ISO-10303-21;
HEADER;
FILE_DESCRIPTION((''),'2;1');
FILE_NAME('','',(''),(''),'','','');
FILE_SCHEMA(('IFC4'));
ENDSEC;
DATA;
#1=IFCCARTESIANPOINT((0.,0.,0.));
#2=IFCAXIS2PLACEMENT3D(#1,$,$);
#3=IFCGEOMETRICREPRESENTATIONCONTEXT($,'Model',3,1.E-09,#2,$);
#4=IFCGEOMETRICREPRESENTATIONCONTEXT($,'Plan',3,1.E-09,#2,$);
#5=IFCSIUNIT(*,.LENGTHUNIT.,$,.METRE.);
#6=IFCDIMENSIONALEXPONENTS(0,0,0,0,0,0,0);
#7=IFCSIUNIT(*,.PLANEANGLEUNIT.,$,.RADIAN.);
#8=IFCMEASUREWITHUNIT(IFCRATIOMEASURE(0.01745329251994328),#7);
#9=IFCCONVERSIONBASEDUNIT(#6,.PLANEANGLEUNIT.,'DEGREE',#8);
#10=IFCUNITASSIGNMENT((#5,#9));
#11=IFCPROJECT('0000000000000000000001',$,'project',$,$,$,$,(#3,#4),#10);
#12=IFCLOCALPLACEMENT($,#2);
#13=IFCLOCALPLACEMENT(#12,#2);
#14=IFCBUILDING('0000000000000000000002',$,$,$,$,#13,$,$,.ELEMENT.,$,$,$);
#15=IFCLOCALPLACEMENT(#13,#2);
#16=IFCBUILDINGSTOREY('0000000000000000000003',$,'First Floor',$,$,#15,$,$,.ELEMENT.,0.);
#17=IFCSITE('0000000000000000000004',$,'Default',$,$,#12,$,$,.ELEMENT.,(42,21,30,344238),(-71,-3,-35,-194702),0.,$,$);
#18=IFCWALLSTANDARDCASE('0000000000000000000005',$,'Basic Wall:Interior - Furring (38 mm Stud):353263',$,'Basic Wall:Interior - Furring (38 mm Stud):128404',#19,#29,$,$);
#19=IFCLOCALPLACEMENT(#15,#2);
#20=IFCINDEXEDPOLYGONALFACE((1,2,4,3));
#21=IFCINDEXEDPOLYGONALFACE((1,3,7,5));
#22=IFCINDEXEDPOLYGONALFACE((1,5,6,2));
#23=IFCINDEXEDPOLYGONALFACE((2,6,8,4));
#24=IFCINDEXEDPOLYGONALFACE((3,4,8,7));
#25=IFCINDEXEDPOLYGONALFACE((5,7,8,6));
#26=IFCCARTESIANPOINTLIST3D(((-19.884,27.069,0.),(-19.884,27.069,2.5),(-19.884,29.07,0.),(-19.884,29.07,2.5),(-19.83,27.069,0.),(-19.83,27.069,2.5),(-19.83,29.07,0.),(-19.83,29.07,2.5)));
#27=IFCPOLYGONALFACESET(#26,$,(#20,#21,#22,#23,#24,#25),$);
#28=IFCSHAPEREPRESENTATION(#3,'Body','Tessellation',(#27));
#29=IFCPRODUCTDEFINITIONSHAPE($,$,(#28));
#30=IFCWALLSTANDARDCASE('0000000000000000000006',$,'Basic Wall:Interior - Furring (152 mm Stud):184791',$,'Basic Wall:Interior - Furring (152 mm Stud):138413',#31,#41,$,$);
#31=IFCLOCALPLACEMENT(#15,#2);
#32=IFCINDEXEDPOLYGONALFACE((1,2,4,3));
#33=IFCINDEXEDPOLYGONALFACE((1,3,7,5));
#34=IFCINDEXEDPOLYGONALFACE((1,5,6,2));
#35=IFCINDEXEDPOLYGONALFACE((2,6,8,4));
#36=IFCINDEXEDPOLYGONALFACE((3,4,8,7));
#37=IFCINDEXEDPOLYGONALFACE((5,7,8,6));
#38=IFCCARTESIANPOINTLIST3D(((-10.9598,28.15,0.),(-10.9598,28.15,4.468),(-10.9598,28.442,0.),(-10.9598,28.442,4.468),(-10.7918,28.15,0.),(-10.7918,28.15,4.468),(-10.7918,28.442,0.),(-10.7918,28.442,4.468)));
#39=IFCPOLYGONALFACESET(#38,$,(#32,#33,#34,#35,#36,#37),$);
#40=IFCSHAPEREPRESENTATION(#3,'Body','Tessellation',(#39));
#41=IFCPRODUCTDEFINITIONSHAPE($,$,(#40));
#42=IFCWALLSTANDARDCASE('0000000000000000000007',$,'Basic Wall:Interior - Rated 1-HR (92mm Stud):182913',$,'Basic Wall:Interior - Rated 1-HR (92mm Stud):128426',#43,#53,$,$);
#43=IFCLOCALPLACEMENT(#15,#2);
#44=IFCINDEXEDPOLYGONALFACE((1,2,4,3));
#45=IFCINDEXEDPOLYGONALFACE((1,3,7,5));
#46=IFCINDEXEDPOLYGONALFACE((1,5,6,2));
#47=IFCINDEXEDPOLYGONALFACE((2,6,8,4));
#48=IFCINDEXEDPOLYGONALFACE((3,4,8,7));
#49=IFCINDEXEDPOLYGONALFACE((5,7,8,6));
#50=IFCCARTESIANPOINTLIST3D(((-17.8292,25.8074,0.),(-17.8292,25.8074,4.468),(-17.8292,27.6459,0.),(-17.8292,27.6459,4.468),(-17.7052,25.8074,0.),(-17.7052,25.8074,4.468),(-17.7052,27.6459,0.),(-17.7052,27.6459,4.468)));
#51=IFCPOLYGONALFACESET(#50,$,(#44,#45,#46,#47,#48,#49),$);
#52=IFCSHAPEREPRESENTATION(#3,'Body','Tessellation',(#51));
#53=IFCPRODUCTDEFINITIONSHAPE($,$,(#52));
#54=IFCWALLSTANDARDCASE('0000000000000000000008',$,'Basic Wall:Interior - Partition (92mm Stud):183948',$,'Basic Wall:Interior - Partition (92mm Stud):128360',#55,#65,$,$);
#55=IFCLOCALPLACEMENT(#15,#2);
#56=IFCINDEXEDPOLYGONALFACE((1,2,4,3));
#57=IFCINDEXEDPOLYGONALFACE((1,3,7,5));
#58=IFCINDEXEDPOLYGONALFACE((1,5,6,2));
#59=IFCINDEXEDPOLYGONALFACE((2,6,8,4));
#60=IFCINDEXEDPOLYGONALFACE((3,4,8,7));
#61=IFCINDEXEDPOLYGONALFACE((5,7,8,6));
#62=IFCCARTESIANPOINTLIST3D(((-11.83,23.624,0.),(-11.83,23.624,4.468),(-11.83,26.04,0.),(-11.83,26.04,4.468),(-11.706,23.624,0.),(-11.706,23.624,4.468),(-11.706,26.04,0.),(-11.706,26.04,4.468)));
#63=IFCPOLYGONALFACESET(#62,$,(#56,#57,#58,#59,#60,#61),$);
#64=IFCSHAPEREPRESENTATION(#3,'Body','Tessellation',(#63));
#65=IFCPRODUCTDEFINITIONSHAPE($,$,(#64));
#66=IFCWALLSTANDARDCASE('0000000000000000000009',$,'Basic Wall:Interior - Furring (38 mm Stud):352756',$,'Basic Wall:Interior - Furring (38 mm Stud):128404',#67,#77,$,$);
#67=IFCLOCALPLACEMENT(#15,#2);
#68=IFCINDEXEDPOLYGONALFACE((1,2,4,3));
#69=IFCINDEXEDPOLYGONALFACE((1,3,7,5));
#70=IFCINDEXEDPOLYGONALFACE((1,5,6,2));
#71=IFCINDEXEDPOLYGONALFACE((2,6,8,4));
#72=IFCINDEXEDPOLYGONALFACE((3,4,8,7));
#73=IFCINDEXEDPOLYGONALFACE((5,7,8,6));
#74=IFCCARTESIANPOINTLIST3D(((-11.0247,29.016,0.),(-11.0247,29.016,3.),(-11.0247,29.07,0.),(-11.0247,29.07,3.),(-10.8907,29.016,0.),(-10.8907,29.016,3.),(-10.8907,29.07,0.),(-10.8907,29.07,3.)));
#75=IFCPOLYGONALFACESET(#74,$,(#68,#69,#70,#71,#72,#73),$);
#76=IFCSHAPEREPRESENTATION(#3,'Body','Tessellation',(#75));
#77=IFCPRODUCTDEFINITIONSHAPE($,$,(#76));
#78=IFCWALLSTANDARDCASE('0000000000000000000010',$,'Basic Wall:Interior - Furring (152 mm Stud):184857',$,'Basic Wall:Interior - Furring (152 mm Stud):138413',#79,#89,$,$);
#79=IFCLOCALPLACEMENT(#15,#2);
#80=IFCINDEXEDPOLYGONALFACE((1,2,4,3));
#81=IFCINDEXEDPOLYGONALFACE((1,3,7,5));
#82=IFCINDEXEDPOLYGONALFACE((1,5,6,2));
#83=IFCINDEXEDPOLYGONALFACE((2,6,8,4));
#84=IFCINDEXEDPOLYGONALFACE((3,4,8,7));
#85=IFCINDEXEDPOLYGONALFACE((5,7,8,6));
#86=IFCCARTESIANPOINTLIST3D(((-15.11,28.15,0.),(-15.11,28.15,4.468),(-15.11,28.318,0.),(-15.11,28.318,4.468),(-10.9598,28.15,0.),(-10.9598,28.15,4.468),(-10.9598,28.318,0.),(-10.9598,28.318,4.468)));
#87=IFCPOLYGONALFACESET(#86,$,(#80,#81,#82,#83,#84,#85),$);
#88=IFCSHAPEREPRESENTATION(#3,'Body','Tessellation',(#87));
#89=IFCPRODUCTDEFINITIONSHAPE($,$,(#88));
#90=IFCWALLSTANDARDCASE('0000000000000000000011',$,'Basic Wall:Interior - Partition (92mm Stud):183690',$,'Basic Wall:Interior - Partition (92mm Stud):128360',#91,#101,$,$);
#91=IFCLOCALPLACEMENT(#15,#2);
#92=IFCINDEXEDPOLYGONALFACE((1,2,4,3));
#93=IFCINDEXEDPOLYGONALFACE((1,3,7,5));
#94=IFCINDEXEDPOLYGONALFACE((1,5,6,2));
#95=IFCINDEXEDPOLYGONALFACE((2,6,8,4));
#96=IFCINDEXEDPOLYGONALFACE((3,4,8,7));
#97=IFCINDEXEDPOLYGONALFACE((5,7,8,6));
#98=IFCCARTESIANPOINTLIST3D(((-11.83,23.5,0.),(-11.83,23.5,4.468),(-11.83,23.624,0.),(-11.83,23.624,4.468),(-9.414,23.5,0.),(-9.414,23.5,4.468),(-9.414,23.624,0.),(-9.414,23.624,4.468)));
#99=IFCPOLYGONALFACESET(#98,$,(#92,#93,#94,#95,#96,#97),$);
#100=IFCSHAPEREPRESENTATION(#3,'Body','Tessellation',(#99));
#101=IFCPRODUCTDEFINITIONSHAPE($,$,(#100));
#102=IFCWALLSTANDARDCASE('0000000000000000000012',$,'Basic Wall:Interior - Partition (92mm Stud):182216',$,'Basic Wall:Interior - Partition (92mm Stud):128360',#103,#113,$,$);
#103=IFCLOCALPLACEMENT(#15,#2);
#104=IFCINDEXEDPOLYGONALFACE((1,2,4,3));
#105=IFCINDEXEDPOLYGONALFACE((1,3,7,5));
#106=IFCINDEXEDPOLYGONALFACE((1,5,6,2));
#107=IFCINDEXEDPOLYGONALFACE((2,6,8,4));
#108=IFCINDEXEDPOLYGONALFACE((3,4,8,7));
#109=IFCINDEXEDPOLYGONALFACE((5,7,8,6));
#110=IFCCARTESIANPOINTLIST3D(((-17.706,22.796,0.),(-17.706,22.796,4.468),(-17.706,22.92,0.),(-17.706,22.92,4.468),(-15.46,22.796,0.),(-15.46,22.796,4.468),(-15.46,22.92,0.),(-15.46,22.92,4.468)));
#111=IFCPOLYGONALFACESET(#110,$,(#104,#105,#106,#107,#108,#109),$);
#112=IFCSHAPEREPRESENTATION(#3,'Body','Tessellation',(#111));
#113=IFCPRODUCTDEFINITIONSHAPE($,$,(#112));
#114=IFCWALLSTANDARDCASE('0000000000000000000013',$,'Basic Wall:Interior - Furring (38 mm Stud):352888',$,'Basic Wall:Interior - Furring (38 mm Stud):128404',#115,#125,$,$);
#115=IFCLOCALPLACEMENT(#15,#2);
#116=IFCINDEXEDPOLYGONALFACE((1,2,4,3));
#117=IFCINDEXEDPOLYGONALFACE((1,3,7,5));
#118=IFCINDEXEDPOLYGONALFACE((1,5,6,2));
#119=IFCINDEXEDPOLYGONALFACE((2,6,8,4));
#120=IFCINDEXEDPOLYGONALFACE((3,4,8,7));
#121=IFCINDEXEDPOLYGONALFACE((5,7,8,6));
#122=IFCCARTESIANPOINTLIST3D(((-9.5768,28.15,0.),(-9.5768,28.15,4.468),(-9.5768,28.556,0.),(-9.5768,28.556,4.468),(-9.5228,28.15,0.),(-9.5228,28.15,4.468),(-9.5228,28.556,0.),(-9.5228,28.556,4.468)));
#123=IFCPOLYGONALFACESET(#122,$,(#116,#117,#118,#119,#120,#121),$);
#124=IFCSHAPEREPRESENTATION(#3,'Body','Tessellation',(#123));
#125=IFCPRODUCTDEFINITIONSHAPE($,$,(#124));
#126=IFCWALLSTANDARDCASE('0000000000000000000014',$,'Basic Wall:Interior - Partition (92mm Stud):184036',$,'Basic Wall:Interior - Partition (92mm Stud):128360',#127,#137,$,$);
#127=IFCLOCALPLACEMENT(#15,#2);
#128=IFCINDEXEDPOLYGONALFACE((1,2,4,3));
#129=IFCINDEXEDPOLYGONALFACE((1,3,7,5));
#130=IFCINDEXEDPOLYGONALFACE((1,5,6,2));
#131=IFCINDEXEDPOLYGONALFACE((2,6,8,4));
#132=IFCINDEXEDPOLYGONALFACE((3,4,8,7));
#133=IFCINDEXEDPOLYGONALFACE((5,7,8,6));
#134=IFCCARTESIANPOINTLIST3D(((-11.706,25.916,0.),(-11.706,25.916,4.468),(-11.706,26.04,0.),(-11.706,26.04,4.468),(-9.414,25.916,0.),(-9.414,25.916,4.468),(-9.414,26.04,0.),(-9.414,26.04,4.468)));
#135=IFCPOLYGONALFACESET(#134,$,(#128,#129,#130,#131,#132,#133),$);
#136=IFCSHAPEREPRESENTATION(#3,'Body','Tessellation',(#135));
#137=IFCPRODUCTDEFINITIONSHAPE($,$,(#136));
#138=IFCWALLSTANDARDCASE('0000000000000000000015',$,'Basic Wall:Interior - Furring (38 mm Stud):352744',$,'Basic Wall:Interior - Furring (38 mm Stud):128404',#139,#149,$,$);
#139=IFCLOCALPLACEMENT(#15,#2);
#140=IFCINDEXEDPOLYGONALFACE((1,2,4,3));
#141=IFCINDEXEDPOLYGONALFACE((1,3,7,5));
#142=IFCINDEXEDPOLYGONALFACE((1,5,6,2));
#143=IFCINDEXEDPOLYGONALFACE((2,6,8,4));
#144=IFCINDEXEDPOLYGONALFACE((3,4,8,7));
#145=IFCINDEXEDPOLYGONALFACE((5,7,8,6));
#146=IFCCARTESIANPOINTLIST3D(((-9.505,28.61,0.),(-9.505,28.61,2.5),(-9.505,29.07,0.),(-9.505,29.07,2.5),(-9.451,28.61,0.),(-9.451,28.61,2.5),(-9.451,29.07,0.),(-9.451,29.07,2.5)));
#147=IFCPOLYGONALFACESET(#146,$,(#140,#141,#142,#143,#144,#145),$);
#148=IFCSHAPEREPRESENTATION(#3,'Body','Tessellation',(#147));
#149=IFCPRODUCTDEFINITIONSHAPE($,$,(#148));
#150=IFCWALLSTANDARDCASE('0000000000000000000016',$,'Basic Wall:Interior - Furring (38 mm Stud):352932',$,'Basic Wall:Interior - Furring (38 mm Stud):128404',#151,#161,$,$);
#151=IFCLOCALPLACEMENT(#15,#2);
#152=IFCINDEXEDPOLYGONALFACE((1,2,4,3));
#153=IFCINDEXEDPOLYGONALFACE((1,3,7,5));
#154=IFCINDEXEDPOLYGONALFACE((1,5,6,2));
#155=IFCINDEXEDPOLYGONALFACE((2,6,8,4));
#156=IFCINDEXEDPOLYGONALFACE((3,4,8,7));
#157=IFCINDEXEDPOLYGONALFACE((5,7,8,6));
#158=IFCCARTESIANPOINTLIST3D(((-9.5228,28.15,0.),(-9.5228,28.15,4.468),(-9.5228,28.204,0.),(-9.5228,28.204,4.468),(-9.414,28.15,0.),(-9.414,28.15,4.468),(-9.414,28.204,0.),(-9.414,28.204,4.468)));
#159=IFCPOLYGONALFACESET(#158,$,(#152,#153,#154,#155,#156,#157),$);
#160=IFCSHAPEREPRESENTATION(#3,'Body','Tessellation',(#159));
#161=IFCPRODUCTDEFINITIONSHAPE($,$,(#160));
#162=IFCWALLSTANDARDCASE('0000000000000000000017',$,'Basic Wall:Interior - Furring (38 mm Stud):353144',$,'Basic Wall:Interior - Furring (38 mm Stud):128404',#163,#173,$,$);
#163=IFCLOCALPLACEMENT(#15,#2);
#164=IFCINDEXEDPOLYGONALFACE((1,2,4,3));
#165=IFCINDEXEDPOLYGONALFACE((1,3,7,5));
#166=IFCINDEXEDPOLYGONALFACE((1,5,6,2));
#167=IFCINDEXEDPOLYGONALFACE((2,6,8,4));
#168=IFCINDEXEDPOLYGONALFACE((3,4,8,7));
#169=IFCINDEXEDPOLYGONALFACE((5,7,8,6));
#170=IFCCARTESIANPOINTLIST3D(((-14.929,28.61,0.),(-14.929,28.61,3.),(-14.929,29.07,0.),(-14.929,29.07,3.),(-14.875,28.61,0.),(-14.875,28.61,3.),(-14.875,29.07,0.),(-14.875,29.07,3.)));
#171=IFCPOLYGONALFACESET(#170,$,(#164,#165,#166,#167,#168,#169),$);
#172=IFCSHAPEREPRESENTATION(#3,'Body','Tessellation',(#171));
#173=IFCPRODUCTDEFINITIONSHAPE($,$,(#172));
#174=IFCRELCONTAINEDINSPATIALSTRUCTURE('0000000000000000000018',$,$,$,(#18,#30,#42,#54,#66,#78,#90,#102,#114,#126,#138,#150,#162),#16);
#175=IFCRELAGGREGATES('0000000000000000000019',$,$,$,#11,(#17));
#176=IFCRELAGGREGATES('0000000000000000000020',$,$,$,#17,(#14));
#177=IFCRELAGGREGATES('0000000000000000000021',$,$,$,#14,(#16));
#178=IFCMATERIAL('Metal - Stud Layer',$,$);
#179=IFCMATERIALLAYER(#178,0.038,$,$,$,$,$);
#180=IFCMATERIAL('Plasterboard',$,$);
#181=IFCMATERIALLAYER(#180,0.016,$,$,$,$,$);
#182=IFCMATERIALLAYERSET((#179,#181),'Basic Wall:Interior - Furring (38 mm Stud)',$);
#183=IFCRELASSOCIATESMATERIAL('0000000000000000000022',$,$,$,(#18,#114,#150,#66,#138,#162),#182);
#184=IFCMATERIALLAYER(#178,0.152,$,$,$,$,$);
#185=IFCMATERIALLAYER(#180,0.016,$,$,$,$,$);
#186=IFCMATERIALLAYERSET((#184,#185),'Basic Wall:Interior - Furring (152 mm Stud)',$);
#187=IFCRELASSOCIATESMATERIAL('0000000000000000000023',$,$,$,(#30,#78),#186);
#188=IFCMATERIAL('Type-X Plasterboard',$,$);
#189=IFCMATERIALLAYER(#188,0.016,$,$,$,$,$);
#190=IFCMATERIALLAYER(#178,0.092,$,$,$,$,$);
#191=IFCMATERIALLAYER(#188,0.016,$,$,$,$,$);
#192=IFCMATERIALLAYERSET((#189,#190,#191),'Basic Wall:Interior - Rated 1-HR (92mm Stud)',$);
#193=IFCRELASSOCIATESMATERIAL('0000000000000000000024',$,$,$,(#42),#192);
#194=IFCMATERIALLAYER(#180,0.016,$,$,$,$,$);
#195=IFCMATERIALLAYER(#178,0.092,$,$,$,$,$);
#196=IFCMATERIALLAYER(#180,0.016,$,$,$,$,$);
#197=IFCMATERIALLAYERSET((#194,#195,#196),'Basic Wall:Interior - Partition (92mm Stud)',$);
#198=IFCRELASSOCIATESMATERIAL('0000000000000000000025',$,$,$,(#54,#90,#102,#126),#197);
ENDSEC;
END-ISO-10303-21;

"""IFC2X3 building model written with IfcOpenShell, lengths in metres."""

from ifc_helpers import new_model, entity, si_unit, converted_unit, frame, frame_2d, origin, place, context, project, spatial, rectangle, extrude, material, layer, layer_set, layer_usage, element, save


model = new_model("IFC2X3")

# Units and contexts
model_context = context("Model", 3, precision=1e-09, world=origin())
plan_context = context("Plan", 3, precision=1e-09, world=origin())
ifc_project = project(units=[si_unit("LENGTHUNIT", "METRE"), converted_unit("PLANEANGLEUNIT", "DEGREE", entity("IfcRatioMeasure", 0.01745329251994328), si_unit("PLANEANGLEUNIT", "RADIAN"), dimensions=[0, 0, 0, 0, 0, 0, 0])], contexts=[model_context, plan_context])

# Site, building, storey
site_placement = place(None, origin())
site = spatial("IfcSite", under=ifc_project, at=site_placement, Name="Default", CompositionType="ELEMENT", RefLatitude=(42, 21, 30, 344238), RefLongitude=(-71, -3, -35, -194702), RefElevation=0.0)
building_placement = place(site_placement, origin())
building = spatial("IfcBuilding", under=site, at=building_placement, CompositionType="ELEMENT")
storey_placement = place(building_placement, origin())
storey = spatial("IfcBuildingStorey", under=building, at=storey_placement, Name="First Floor", CompositionType="ELEMENT", Elevation=0.0)

# Shared definitions
ifc_material_1 = material(Name="Type-X Plasterboard")
ifc_layer_1 = layer(ifc_material_1, 0.016)
ifc_material_2 = material(Name="Metal - Stud Layer")
ifc_layer_2 = layer(ifc_material_2, 0.092)
ifc_layer_3 = layer(ifc_material_1, 0.016)
ifc_layer_set_1 = layer_set([ifc_layer_1, ifc_layer_2, ifc_layer_3], Name="Basic Wall:Interior - Rated 1-HR (92mm Stud)")
ifc_layer_usage_1 = layer_usage(ifc_layer_set_1, "AXIS2", "NEGATIVE", 0.062)

# Shared definitions
ifc_layer_4 = layer(ifc_material_2, 0.038)
ifc_material_3 = material(Name="Plasterboard")
ifc_layer_5 = layer(ifc_material_3, 0.016)
ifc_layer_set_2 = layer_set([ifc_layer_4, ifc_layer_5], Name="Basic Wall:Interior - Furring (38 mm Stud)")
ifc_layer_usage_2 = layer_usage(ifc_layer_set_2, "AXIS2", "POSITIVE", -0.027)

# Shared definitions
ifc_layer_6 = layer(ifc_material_3, 0.016)
ifc_layer_7 = layer(ifc_material_2, 0.092)
ifc_layer_8 = layer(ifc_material_3, 0.016)
ifc_layer_set_3 = layer_set([ifc_layer_6, ifc_layer_7, ifc_layer_8], Name="Basic Wall:Interior - Partition (92mm Stud)")
ifc_layer_usage_3 = layer_usage(ifc_layer_set_3, "AXIS2", "NEGATIVE", 0.062)

# Walls
ifc_layer_usage_4 = layer_usage(ifc_layer_set_2, "AXIS2", "NEGATIVE", 0.027)
wall_1_placement = place(storey_placement, frame((-19.857, 27.069, 0.0), z_axis=(0.0, 0.0, 1.0), x_axis=(0.0, 1.0, 0.0)))
element("IfcWallStandardCase", 1, at=wall_1_placement, inside=storey, material=ifc_layer_usage_4, Name="Basic Wall:Interior - Furring (38 mm Stud):353263", ObjectType="Basic Wall:Interior - Furring (38 mm Stud):128404", context=model_context, shape_type="SweptSolid", body=[
    extrude(rectangle(XDim=2.001, YDim=0.054, at=frame_2d((1.0005, 0.0), x_axis=(-1.0, 0.0))), origin(), (0.0, 0.0, 1.0), 2.5),
])
ifc_layer_9 = layer(ifc_material_2, 0.152)
ifc_layer_10 = layer(ifc_material_3, 0.016)
ifc_layer_set_4 = layer_set([ifc_layer_9, ifc_layer_10], Name="Basic Wall:Interior - Furring (152 mm Stud)")
ifc_layer_usage_5 = layer_usage(ifc_layer_set_4, "AXIS2", "POSITIVE", -0.084)
wall_2_placement = place(storey_placement, frame((-10.8758, 28.442, 0.0), z_axis=(0.0, 0.0, 1.0), x_axis=(0.0, -1.0, 0.0)))
element("IfcWallStandardCase", 2, at=wall_2_placement, inside=storey, material=ifc_layer_usage_5, Name="Basic Wall:Interior - Furring (152 mm Stud):184791", ObjectType="Basic Wall:Interior - Furring (152 mm Stud):138413", context=model_context, shape_type="SweptSolid", body=[
    extrude(rectangle(XDim=0.292, YDim=0.168, at=frame_2d((0.146, 0.0), x_axis=(-1.0, 0.0))), origin(), (0.0, 0.0, 1.0), 4.468),
])
wall_3_placement = place(storey_placement, frame((-17.7672, 25.8074, 0.0), z_axis=(0.0, 0.0, 1.0), x_axis=(0.0, 1.0, 0.0)))
element("IfcWallStandardCase", 3, at=wall_3_placement, inside=storey, material=ifc_layer_usage_1, Name="Basic Wall:Interior - Rated 1-HR (92mm Stud):182913", ObjectType="Basic Wall:Interior - Rated 1-HR (92mm Stud):128426", context=model_context, shape_type="SweptSolid", body=[
    extrude(rectangle(XDim=1.8385, YDim=0.124, at=frame_2d((0.9192, 0.0), x_axis=(-1.0, 0.0))), origin(), (0.0, 0.0, 1.0), 4.468),
])
wall_4_placement = place(storey_placement, frame((-11.768, 23.624, 0.0), z_axis=(0.0, 0.0, 1.0), x_axis=(0.0, 1.0, 0.0)))
element("IfcWallStandardCase", 4, at=wall_4_placement, inside=storey, material=ifc_layer_usage_3, Name="Basic Wall:Interior - Partition (92mm Stud):183948", ObjectType="Basic Wall:Interior - Partition (92mm Stud):128360", context=model_context, shape_type="SweptSolid", body=[
    extrude(rectangle(XDim=2.416, YDim=0.124, at=frame_2d((1.208, 0.0), x_axis=(-1.0, 0.0))), origin(), (0.0, 0.0, 1.0), 4.468),
])
wall_5_placement = place(storey_placement, frame((-11.0247, 29.043, 0.0)))
element("IfcWallStandardCase", 5, at=wall_5_placement, inside=storey, material=ifc_layer_usage_2, Name="Basic Wall:Interior - Furring (38 mm Stud):352756", ObjectType="Basic Wall:Interior - Furring (38 mm Stud):128404", context=model_context, shape_type="SweptSolid", body=[
    extrude(rectangle(XDim=0.134, YDim=0.054, at=frame_2d((0.067, 0.0), x_axis=(-1.0, 0.0))), origin(), (0.0, 0.0, 1.0), 3.0),
])
wall_6_placement = place(storey_placement, frame((-10.9598, 28.234, 0.0), z_axis=(0.0, 0.0, 1.0), x_axis=(-1.0, 0.0, 0.0)))
element("IfcWallStandardCase", 6, at=wall_6_placement, inside=storey, material=ifc_layer_usage_5, Name="Basic Wall:Interior - Furring (152 mm Stud):184857", ObjectType="Basic Wall:Interior - Furring (152 mm Stud):138413", context=model_context, shape_type="SweptSolid", body=[
    extrude(rectangle(XDim=4.1502, YDim=0.168, at=frame_2d((2.0751, 0.0), x_axis=(-1.0, 0.0))), origin(), (0.0, 0.0, 1.0), 4.468),
])
wall_7_placement = place(storey_placement, frame((-9.414, 23.562, 0.0), z_axis=(0.0, 0.0, 1.0), x_axis=(-1.0, 0.0, 0.0)))
element("IfcWallStandardCase", 7, at=wall_7_placement, inside=storey, material=ifc_layer_usage_3, Name="Basic Wall:Interior - Partition (92mm Stud):183690", ObjectType="Basic Wall:Interior - Partition (92mm Stud):128360", context=model_context, shape_type="SweptSolid", body=[
    extrude(rectangle(XDim=2.416, YDim=0.124, at=frame_2d((1.208, 0.0), x_axis=(-1.0, 0.0))), origin(), (0.0, 0.0, 1.0), 4.468),
])
wall_8_placement = place(storey_placement, frame((-17.706, 22.858, 0.0)))
element("IfcWallStandardCase", 8, at=wall_8_placement, inside=storey, material=ifc_layer_usage_3, Name="Basic Wall:Interior - Partition (92mm Stud):182216", ObjectType="Basic Wall:Interior - Partition (92mm Stud):128360", context=model_context, shape_type="SweptSolid", body=[
    extrude(rectangle(XDim=2.246, YDim=0.124, at=frame_2d((1.123, 0.0), x_axis=(-1.0, 0.0))), origin(), (0.0, 0.0, 1.0), 4.468),
])
wall_9_placement = place(storey_placement, frame((-9.5498, 28.556, 0.0), z_axis=(0.0, 0.0, 1.0), x_axis=(0.0, -1.0, 0.0)))
element("IfcWallStandardCase", 9, at=wall_9_placement, inside=storey, material=ifc_layer_usage_4, Name="Basic Wall:Interior - Furring (38 mm Stud):352888", ObjectType="Basic Wall:Interior - Furring (38 mm Stud):128404", context=model_context, shape_type="SweptSolid", body=[
    extrude(rectangle(XDim=0.406, YDim=0.054, at=frame_2d((0.203, 0.0), x_axis=(-1.0, 0.0))), origin(), (0.0, 0.0, 1.0), 4.468),
])
wall_10_placement = place(storey_placement, frame((-11.706, 25.978, 0.0)))
element("IfcWallStandardCase", 10, at=wall_10_placement, inside=storey, material=ifc_layer_usage_3, Name="Basic Wall:Interior - Partition (92mm Stud):184036", ObjectType="Basic Wall:Interior - Partition (92mm Stud):128360", context=model_context, shape_type="SweptSolid", body=[
    extrude(rectangle(XDim=2.292, YDim=0.124, at=frame_2d((1.146, 0.0), x_axis=(-1.0, 0.0))), origin(), (0.0, 0.0, 1.0), 4.468),
])
wall_11_placement = place(storey_placement, frame((-9.478, 28.61, 0.0), z_axis=(0.0, 0.0, 1.0), x_axis=(0.0, 1.0, 0.0)))
element("IfcWallStandardCase", 11, at=wall_11_placement, inside=storey, material=ifc_layer_usage_2, Name="Basic Wall:Interior - Furring (38 mm Stud):352744", ObjectType="Basic Wall:Interior - Furring (38 mm Stud):128404", context=model_context, shape_type="SweptSolid", body=[
    extrude(rectangle(XDim=0.46, YDim=0.054, at=frame_2d((0.23, 0.0), x_axis=(-1.0, 0.0))), origin(), (0.0, 0.0, 1.0), 2.5),
])
wall_12_placement = place(storey_placement, frame((-9.5228, 28.177, 0.0)))
element("IfcWallStandardCase", 12, at=wall_12_placement, inside=storey, material=ifc_layer_usage_4, Name="Basic Wall:Interior - Furring (38 mm Stud):352932", ObjectType="Basic Wall:Interior - Furring (38 mm Stud):128404", context=model_context, shape_type="SweptSolid", body=[
    extrude(rectangle(XDim=0.1089, YDim=0.054, at=frame_2d((0.0544, 0.0), x_axis=(-1.0, 0.0))), origin(), (0.0, 0.0, 1.0), 4.468),
])
wall_13_placement = place(storey_placement, frame((-14.902, 29.07, 0.0), z_axis=(0.0, 0.0, 1.0), x_axis=(0.0, -1.0, 0.0)))
element("IfcWallStandardCase", 13, at=wall_13_placement, inside=storey, material=ifc_layer_usage_2, Name="Basic Wall:Interior - Furring (38 mm Stud):353144", ObjectType="Basic Wall:Interior - Furring (38 mm Stud):128404", context=model_context, shape_type="SweptSolid", body=[
    extrude(rectangle(XDim=0.46, YDim=0.054, at=frame_2d((0.23, 0.0), x_axis=(-1.0, 0.0))), origin(), (0.0, 0.0, 1.0), 3.0),
])

save(model, "model.ifc")
